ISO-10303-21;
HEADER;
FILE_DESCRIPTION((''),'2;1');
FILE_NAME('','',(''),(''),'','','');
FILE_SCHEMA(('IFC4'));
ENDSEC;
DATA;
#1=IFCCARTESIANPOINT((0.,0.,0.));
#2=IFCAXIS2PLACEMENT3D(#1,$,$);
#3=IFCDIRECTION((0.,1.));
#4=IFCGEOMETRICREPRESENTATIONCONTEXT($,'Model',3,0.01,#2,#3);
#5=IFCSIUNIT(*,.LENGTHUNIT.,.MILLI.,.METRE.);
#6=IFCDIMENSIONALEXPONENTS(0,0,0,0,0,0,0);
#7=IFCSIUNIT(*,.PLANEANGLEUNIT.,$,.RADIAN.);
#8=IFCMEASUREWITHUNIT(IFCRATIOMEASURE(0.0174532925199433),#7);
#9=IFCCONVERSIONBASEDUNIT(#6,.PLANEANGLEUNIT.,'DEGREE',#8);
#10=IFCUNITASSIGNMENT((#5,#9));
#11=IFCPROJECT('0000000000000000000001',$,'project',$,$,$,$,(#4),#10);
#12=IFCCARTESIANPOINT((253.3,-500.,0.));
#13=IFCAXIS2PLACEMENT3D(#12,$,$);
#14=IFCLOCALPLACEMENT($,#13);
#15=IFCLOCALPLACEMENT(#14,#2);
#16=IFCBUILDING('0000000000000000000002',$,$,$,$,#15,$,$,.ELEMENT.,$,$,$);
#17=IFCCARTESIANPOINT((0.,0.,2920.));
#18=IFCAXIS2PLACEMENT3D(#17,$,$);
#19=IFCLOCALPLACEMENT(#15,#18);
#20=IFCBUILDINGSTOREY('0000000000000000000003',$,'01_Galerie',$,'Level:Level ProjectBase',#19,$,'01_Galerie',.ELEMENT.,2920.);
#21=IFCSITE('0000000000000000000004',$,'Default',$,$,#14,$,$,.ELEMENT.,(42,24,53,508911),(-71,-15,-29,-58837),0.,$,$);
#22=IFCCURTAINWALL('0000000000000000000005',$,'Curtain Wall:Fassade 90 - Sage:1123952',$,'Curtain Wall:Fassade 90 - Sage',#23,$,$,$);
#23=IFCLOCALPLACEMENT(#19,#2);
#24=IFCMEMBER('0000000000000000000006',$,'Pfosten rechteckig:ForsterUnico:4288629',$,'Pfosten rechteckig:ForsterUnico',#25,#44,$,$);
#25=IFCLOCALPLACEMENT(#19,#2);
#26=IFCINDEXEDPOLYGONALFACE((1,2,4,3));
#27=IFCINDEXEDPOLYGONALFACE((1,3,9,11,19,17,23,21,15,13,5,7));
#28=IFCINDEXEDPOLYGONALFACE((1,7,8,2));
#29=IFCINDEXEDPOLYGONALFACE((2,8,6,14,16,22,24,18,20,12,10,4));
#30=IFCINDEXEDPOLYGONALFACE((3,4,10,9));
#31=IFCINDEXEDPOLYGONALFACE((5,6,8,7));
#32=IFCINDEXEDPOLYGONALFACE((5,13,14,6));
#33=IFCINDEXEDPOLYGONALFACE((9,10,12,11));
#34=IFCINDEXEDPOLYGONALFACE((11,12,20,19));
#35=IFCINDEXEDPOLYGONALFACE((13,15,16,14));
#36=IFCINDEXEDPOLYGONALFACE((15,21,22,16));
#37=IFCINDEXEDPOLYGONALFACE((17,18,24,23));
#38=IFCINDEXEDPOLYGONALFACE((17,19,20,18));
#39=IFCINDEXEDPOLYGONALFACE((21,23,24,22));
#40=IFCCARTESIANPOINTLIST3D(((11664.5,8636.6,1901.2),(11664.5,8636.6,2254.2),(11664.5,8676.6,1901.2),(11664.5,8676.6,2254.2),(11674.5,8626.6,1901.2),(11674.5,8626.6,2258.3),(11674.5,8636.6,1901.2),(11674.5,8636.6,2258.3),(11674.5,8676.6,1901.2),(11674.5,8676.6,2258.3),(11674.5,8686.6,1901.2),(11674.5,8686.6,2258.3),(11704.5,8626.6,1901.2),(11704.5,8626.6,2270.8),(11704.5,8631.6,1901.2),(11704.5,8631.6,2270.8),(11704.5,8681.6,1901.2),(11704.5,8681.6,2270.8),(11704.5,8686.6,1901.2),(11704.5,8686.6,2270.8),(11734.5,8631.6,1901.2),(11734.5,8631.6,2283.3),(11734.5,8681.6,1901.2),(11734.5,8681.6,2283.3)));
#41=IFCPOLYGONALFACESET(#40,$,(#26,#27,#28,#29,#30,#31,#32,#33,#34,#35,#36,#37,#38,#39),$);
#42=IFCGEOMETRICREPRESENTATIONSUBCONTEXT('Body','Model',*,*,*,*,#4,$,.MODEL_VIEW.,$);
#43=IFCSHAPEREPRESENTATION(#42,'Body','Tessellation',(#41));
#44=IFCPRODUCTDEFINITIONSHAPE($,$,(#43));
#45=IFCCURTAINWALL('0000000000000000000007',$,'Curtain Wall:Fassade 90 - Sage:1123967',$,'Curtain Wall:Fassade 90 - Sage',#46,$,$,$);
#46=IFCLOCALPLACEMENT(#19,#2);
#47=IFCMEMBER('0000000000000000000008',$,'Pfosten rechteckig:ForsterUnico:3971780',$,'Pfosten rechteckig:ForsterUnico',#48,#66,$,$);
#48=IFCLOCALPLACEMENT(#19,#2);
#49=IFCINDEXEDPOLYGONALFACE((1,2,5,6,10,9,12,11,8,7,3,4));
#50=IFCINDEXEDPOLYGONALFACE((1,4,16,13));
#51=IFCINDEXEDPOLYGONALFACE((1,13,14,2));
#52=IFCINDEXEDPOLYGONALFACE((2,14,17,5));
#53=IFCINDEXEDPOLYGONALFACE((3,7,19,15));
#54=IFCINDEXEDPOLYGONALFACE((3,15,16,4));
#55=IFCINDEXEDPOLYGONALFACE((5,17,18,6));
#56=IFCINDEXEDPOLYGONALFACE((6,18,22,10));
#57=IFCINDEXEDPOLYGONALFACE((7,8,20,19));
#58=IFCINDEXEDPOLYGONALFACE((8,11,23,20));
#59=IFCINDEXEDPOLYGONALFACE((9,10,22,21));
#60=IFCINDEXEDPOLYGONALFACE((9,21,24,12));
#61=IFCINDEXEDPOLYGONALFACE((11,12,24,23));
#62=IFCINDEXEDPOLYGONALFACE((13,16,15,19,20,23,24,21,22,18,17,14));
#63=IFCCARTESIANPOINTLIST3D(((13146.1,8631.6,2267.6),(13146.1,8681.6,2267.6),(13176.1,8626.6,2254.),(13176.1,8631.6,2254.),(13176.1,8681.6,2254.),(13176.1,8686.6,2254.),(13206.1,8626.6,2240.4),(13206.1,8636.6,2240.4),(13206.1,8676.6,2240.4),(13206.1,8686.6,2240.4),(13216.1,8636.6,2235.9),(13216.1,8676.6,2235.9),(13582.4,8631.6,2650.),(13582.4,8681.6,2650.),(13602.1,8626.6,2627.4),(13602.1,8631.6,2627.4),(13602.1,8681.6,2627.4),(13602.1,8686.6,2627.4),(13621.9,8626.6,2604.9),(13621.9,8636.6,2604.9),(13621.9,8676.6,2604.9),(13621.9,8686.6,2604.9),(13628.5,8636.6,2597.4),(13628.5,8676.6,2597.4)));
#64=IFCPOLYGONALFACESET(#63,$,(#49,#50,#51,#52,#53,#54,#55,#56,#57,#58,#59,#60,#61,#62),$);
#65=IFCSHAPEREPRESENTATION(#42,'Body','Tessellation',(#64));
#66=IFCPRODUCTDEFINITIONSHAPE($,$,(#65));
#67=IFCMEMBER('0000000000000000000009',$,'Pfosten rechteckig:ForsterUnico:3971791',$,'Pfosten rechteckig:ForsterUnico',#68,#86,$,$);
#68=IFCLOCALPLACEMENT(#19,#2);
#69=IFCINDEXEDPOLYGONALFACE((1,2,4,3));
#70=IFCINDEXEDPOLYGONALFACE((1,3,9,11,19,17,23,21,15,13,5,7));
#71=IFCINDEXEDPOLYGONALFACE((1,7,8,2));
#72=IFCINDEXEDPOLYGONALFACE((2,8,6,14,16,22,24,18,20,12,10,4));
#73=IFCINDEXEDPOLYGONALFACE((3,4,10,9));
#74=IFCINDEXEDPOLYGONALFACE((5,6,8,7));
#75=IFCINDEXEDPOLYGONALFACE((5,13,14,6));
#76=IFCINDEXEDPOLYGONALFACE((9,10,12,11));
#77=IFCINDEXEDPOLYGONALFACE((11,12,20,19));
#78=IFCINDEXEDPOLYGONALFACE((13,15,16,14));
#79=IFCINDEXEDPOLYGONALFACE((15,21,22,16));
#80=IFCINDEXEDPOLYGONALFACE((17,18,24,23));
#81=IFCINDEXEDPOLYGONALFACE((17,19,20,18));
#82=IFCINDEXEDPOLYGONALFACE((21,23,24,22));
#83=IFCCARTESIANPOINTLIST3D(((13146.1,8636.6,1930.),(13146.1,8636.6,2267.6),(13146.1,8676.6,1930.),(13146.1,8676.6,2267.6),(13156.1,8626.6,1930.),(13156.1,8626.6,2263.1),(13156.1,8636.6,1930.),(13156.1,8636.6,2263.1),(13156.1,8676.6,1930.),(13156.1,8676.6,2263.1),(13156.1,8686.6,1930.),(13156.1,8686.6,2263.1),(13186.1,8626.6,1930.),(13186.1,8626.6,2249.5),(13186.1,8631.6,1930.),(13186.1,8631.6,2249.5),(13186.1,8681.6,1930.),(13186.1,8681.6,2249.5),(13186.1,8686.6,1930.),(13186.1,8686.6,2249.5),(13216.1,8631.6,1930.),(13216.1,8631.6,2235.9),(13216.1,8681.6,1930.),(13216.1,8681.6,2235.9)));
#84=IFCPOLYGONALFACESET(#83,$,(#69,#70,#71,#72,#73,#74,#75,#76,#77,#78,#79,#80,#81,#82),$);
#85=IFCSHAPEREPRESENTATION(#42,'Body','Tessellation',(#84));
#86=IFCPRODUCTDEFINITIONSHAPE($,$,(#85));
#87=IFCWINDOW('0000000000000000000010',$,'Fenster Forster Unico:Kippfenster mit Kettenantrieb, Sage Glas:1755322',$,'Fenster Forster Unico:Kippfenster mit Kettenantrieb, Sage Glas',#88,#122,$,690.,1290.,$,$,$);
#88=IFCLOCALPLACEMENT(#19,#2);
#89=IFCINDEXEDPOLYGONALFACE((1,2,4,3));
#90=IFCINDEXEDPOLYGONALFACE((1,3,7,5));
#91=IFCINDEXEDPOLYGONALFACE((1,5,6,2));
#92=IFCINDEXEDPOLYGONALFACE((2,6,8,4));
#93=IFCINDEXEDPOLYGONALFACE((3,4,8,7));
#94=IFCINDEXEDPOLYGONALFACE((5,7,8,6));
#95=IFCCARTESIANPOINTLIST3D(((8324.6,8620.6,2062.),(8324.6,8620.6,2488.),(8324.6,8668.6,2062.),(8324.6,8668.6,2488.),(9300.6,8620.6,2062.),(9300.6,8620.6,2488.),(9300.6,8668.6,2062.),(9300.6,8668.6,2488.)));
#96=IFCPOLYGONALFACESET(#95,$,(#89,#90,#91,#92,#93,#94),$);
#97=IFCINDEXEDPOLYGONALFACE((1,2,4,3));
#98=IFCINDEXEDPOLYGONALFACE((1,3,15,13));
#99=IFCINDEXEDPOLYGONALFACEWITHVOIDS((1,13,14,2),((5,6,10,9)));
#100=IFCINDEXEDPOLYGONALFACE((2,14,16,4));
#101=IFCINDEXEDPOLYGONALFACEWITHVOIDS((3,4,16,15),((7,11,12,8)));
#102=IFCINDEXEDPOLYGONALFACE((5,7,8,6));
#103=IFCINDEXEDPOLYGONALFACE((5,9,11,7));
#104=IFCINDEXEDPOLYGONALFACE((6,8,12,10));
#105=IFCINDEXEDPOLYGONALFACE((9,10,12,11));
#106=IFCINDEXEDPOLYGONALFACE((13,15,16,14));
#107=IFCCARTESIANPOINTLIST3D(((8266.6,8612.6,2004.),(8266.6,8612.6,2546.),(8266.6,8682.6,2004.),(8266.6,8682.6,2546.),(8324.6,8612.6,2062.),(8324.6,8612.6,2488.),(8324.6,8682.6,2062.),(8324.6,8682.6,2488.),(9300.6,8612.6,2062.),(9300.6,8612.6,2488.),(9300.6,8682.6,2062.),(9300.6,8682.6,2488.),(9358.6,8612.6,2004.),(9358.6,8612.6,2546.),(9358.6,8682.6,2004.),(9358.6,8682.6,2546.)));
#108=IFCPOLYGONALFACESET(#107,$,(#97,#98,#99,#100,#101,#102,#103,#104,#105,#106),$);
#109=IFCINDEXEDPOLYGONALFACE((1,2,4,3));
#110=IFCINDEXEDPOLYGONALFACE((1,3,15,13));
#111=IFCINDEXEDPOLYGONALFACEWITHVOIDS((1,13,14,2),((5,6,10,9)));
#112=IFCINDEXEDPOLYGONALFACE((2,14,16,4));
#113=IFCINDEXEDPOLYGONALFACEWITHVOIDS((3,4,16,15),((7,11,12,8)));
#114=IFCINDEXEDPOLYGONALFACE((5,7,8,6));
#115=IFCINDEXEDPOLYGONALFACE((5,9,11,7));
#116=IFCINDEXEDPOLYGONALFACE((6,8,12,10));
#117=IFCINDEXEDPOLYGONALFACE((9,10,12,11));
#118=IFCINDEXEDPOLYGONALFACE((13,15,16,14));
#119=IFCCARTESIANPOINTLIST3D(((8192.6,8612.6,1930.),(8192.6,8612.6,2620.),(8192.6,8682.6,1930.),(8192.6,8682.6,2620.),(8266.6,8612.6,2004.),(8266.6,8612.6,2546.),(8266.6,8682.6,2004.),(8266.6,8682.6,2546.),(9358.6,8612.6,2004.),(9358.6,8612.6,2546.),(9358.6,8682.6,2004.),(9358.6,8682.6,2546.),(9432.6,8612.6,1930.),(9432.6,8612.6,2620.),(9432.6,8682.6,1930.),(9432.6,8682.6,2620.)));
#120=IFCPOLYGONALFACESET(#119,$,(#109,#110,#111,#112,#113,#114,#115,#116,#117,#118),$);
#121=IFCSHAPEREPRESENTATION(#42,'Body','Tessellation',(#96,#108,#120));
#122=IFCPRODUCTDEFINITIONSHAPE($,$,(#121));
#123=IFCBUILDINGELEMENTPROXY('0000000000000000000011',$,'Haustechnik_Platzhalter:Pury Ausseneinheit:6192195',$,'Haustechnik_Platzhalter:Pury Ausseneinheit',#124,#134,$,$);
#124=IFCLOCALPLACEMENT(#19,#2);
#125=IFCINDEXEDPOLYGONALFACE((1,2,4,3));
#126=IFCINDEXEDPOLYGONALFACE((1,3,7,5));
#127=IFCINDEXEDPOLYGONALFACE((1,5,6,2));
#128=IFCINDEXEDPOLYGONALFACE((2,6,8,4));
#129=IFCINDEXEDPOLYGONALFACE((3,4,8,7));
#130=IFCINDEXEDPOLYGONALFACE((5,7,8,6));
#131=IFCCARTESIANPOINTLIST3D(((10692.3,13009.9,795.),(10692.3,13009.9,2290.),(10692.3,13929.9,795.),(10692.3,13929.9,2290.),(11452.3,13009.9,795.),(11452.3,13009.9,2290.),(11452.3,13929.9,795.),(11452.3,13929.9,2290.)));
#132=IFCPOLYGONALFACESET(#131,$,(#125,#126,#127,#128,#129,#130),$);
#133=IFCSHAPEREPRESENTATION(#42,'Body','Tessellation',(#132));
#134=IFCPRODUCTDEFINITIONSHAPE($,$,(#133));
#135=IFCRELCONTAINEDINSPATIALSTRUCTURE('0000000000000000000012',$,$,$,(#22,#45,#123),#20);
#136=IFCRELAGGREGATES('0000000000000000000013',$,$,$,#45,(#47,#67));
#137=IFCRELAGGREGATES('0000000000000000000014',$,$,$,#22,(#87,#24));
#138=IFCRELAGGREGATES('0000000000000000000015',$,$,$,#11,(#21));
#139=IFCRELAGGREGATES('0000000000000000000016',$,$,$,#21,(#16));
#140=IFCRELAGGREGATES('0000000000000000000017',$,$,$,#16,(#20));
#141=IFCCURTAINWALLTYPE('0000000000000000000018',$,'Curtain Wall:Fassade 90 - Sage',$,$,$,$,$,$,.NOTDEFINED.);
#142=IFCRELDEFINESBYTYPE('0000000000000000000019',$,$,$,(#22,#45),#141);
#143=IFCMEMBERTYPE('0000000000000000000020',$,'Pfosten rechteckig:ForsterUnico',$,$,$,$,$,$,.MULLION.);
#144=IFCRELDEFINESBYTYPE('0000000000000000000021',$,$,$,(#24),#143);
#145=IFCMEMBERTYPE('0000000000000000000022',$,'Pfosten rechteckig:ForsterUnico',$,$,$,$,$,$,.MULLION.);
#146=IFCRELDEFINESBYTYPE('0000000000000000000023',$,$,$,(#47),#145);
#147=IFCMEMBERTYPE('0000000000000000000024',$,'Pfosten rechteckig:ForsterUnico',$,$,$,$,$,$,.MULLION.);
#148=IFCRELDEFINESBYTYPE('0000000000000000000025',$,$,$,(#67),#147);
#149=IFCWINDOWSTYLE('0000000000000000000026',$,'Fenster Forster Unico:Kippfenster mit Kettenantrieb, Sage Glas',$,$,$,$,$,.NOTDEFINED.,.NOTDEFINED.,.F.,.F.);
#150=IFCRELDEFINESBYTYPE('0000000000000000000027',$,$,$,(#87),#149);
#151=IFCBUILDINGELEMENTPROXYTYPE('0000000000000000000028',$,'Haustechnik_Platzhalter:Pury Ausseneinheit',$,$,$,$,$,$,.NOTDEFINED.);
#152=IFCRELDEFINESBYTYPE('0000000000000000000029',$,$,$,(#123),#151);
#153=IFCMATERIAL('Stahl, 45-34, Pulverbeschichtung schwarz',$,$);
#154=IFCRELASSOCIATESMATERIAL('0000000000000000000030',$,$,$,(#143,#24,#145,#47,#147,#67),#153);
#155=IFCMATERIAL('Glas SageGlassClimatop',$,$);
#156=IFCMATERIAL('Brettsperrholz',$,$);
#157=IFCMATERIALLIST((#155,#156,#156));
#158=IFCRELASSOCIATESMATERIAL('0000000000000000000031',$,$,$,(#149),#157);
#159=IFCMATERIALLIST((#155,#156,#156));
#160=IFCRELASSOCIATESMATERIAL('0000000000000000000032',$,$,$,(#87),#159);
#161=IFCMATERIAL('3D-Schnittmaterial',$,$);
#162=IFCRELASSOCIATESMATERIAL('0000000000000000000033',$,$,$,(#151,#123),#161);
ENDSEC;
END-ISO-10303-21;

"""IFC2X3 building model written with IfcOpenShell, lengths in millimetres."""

from ifc_helpers import new_model, entity, si_unit, converted_unit, direction, frame, origin, origin_2d_with_axis, place, context, subcontext, project, spatial, polyline, rectangle, outline, extrude, clip, halfspace, source, transform, mapped, material, material_list, type_object, type_shapes, element, aggregate, save


model = new_model("IFC2X3")

# Units and contexts
model_context = context("Model", 3, precision=0.01, world=origin(), true_north=direction((0.0, 1.0)))
body_context = subcontext(model_context, "Body", "Model", "MODEL_VIEW")
ifc_project = project(units=[si_unit("LENGTHUNIT", "METRE", prefix="MILLI"), converted_unit("PLANEANGLEUNIT", "DEGREE", entity("IfcRatioMeasure", 0.0174532925199433), si_unit("PLANEANGLEUNIT", "RADIAN"), dimensions=[0, 0, 0, 0, 0, 0, 0])], contexts=[model_context])

# Site, building, storey
site_placement = place(None, frame((253.3, -500.0, 0.0)))
site = spatial("IfcSite", under=ifc_project, at=site_placement, Name="Default", CompositionType="ELEMENT", RefLatitude=(42, 24, 53, 508911), RefLongitude=(-71, -15, -29, -58837), RefElevation=0.0)
building_placement = place(site_placement, origin())
building = spatial("IfcBuilding", under=site, at=building_placement, CompositionType="ELEMENT")
storey_placement = place(building_placement, frame((0.0, 0.0, 2920.0)))
storey = spatial("IfcBuildingStorey", under=building, at=storey_placement, Name="01_Galerie", ObjectType="Level:Level ProjectBase", LongName="01_Galerie", CompositionType="ELEMENT", Elevation=2920.0)

# Curtain walls, members
curtain_wall_type = type_object("IfcCurtainWallType", Name="Curtain Wall:Fassade 90 - Sage", PredefinedType="NOTDEFINED")
curtain_wall_1_placement = place(storey_placement, frame((0.0, 0.0, -2920.0)))
curtain_wall_1 = element("IfcCurtainWall", 1, at=curtain_wall_1_placement, inside=storey, type_object=curtain_wall_type, Name="Curtain Wall:Fassade 90 - Sage:1123952", ObjectType="Curtain Wall:Fassade 90 - Sage")
ifc_material_1 = material(Name="Stahl, 45-34, Pulverbeschichtung schwarz")
member_type_1 = type_object("IfcMemberType", Name="Pfosten rechteckig:ForsterUnico", PredefinedType="MULLION", material=ifc_material_1)
shared_shape_1 = source(origin(), body_context, "Body", "Clipping", [
    clip(extrude(outline(polyline([(-20.0, -28.3), (20.0, -28.3), (20.0, -18.3), (30.0, -18.3), (30.0, 11.7), (25.0, 11.7), (25.0, 41.7), (-25.0, 41.7), (-25.0, 11.7), (-30.0, 11.7), (-30.0, -18.3), (-20.0, -18.3), (-20.0, -28.3)])), frame((-41.7, 0.0, -382.1), z_axis=(0.0, 0.0, 1.0), x_axis=(0.0, -1.0, 0.0)), (0.0, 0.0, 1.0), 382.1), halfspace(frame((0.0, -304.8, -382.1), z_axis=(-0.384128, 0.0, -0.92328), x_axis=(-0.92328, 0.0, 0.384128)), False)),
])
type_shapes(member_type_1, [shared_shape_1])
member_1_placement = place(storey_placement, frame((11734.5, 8656.6, 1901.2), z_axis=(0.0, 0.0, -1.0), x_axis=(1.0, 0.0, 0.0)))
member_1 = element("IfcMember", 2, at=member_1_placement, type_object=member_type_1, material=ifc_material_1, Name="Pfosten rechteckig:ForsterUnico:4288629", ObjectType="Pfosten rechteckig:ForsterUnico", context=body_context, shape_type="MappedRepresentation", body=[
    mapped(shared_shape_1, transform((0.0, 0.0, 0.0), scale=1.0)),
])
curtain_wall_2_placement = place(storey_placement, frame((0.0, 0.0, -2920.0)))
curtain_wall_2 = element("IfcCurtainWall", 3, at=curtain_wall_2_placement, inside=storey, type_object=curtain_wall_type, Name="Curtain Wall:Fassade 90 - Sage:1123967", ObjectType="Curtain Wall:Fassade 90 - Sage")
member_type_2 = type_object("IfcMemberType", Name="Pfosten rechteckig:ForsterUnico", PredefinedType="MULLION", material=ifc_material_1)
shared_shape_2 = source(origin(), body_context, "Body", "Clipping", [
    clip(extrude(outline(polyline([(-20.0, -28.3), (20.0, -28.3), (20.0, -18.3), (30.0, -18.3), (30.0, 11.7), (25.0, 11.7), (25.0, 41.7), (-25.0, 41.7), (-25.0, 11.7), (-30.0, 11.7), (-30.0, -18.3), (-20.0, -18.3), (-20.0, -28.3)])), frame((-41.7, 0.0, -580.1), z_axis=(0.0, 0.0, 1.0), x_axis=(0.0, -1.0, 0.0)), (0.0, 0.0, 1.0), 580.1), halfspace(frame((0.0, -304.8, -580.1), z_axis=(-0.412825, 0.0, -0.91081), x_axis=(-0.91081, 0.0, 0.412825)), False)),
])
type_shapes(member_type_2, [shared_shape_2])
member_2_placement = place(storey_placement, frame((13582.4, 8656.6, 2650.0), z_axis=(0.752011, 0.0, 0.65915), x_axis=(-0.65915, 0.0, 0.752011)))
member_2 = element("IfcMember", 4, at=member_2_placement, type_object=member_type_2, material=ifc_material_1, Name="Pfosten rechteckig:ForsterUnico:3971780", ObjectType="Pfosten rechteckig:ForsterUnico", context=body_context, shape_type="MappedRepresentation", body=[
    mapped(shared_shape_2, transform((0.0, 0.0, 0.0), scale=1.0)),
])
member_type_3 = type_object("IfcMemberType", Name="Pfosten rechteckig:ForsterUnico", PredefinedType="MULLION", material=ifc_material_1)
shared_shape_3 = source(origin(), body_context, "Body", "Clipping", [
    clip(extrude(outline(polyline([(-25.0, -41.7), (25.0, -41.7), (25.0, -11.7), (30.0, -11.7), (30.0, 18.3), (20.0, 18.3), (20.0, 28.3), (-20.0, 28.3), (-20.0, 18.3), (-30.0, 18.3), (-30.0, -11.7), (-25.0, -11.7), (-25.0, -41.7)])), frame((-28.3, 0.0, -337.6), z_axis=(0.0, 0.0, 1.0), x_axis=(0.0, -1.0, 0.0)), (0.0, 0.0, 1.0), 337.6), halfspace(frame((0.0, -304.8, 0.0), z_axis=(-0.412825, 0.0, 0.91081), x_axis=(-0.91081, 0.0, -0.412825)), False)),
])
type_shapes(member_type_3, [shared_shape_3])
member_3_placement = place(storey_placement, frame((13146.1, 8656.6, 2267.6), z_axis=(0.0, 0.0, 1.0), x_axis=(-1.0, 0.0, 0.0)))
member_3 = element("IfcMember", 5, at=member_3_placement, type_object=member_type_3, material=ifc_material_1, Name="Pfosten rechteckig:ForsterUnico:3971791", ObjectType="Pfosten rechteckig:ForsterUnico", context=body_context, shape_type="MappedRepresentation", body=[
    mapped(shared_shape_3, transform((0.0, 0.0, 0.0), scale=1.0)),
])

# Shared definitions
ifc_material_2 = material(Name="Glas SageGlassClimatop")
aggregate(curtain_wall_2, [member_2, member_3])

# Window
ifc_material_3 = material(Name="Brettsperrholz")
ifc_material_list_1 = material_list([ifc_material_2, ifc_material_3, ifc_material_3])
ifc_material_list_2 = material_list([ifc_material_2, ifc_material_3, ifc_material_3])
window_style = type_object("IfcWindowStyle", Name="Fenster Forster Unico:Kippfenster mit Kettenantrieb, Sage Glas", ConstructionType="NOTDEFINED", OperationType="NOTDEFINED", ParameterTakesPrecedence=False, Sizeable=False, material=ifc_material_list_2)
shared_shape_4 = source(origin(), body_context, "Body", "SweptSolid", [
    extrude(rectangle(XDim=976.0, YDim=48.0, at=origin_2d_with_axis()), frame((0.0, -12.0, 157.0), z_axis=(0.0, 0.0, 1.0), x_axis=(-1.0, 0.0, 0.0)), (0.0, 0.0, 1.0), 426.0),
    extrude(outline(polyline([(-271.0, -546.0), (271.0, -546.0), (271.0, 546.0), (-271.0, 546.0), (-271.0, -546.0)]), holes=[polyline([(213.0, -488.0), (-213.0, -488.0), (-213.0, 488.0), (213.0, 488.0), (213.0, -488.0)])]), frame((0.0, -44.0, 370.0), z_axis=(0.0, 1.0, 0.0), x_axis=(0.0, 0.0, 1.0)), (0.0, 0.0, 1.0), 70.0),
    extrude(outline(polyline([(-345.0, -620.0), (345.0, -620.0), (345.0, 620.0), (-345.0, 620.0), (-345.0, -620.0)]), holes=[polyline([(271.0, -546.0), (-271.0, -546.0), (-271.0, 546.0), (271.0, 546.0), (271.0, -546.0)])]), frame((0.0, -44.0, 370.0), z_axis=(0.0, 1.0, 0.0), x_axis=(0.0, 0.0, 1.0)), (0.0, 0.0, 1.0), 70.0),
])
type_shapes(window_style, [shared_shape_4])
window_placement = place(curtain_wall_1_placement, frame((8812.6, 8656.6, 4825.0)))
window = element("IfcWindow", 6, at=window_placement, type_object=window_style, material=ifc_material_list_1, Name="Fenster Forster Unico:Kippfenster mit Kettenantrieb, Sage Glas:1755322", ObjectType="Fenster Forster Unico:Kippfenster mit Kettenantrieb, Sage Glas", OverallHeight=690.0, OverallWidth=1290.0, context=body_context, shape_type="MappedRepresentation", body=[
    mapped(shared_shape_4, transform((0.0, 0.0, 0.0), scale=1.0)),
])
aggregate(curtain_wall_1, [window, member_1])

# Building element proxy
ifc_material_4 = material(Name="3D-Schnittmaterial")
building_element_proxy_type = type_object("IfcBuildingElementProxyType", Name="Haustechnik_Platzhalter:Pury Ausseneinheit", PredefinedType="NOTDEFINED", material=ifc_material_4)
shared_shape_5 = source(origin(), body_context, "Body", "SweptSolid", [
    extrude(rectangle(XDim=920.0, YDim=760.0, at=origin_2d_with_axis()), frame((0.0, 0.0, 0.0), z_axis=(0.0, 0.0, 1.0), x_axis=(-1.0, 0.0, 0.0)), (0.0, 0.0, 1.0), 1495.0),
])
type_shapes(building_element_proxy_type, [shared_shape_5])
proxy_placement = place(storey_placement, frame((11072.3, 13469.9, 795.0), z_axis=(0.0, 0.0, 1.0), x_axis=(0.0, 1.0, 0.0)))
element("IfcBuildingElementProxy", 7, at=proxy_placement, inside=storey, type_object=building_element_proxy_type, material=ifc_material_4, Name="Haustechnik_Platzhalter:Pury Ausseneinheit:6192195", ObjectType="Haustechnik_Platzhalter:Pury Ausseneinheit", context=body_context, shape_type="MappedRepresentation", body=[
    mapped(shared_shape_5, transform((0.0, 0.0, 0.0), scale=1.0)),
])

save(model, "model.ifc")
